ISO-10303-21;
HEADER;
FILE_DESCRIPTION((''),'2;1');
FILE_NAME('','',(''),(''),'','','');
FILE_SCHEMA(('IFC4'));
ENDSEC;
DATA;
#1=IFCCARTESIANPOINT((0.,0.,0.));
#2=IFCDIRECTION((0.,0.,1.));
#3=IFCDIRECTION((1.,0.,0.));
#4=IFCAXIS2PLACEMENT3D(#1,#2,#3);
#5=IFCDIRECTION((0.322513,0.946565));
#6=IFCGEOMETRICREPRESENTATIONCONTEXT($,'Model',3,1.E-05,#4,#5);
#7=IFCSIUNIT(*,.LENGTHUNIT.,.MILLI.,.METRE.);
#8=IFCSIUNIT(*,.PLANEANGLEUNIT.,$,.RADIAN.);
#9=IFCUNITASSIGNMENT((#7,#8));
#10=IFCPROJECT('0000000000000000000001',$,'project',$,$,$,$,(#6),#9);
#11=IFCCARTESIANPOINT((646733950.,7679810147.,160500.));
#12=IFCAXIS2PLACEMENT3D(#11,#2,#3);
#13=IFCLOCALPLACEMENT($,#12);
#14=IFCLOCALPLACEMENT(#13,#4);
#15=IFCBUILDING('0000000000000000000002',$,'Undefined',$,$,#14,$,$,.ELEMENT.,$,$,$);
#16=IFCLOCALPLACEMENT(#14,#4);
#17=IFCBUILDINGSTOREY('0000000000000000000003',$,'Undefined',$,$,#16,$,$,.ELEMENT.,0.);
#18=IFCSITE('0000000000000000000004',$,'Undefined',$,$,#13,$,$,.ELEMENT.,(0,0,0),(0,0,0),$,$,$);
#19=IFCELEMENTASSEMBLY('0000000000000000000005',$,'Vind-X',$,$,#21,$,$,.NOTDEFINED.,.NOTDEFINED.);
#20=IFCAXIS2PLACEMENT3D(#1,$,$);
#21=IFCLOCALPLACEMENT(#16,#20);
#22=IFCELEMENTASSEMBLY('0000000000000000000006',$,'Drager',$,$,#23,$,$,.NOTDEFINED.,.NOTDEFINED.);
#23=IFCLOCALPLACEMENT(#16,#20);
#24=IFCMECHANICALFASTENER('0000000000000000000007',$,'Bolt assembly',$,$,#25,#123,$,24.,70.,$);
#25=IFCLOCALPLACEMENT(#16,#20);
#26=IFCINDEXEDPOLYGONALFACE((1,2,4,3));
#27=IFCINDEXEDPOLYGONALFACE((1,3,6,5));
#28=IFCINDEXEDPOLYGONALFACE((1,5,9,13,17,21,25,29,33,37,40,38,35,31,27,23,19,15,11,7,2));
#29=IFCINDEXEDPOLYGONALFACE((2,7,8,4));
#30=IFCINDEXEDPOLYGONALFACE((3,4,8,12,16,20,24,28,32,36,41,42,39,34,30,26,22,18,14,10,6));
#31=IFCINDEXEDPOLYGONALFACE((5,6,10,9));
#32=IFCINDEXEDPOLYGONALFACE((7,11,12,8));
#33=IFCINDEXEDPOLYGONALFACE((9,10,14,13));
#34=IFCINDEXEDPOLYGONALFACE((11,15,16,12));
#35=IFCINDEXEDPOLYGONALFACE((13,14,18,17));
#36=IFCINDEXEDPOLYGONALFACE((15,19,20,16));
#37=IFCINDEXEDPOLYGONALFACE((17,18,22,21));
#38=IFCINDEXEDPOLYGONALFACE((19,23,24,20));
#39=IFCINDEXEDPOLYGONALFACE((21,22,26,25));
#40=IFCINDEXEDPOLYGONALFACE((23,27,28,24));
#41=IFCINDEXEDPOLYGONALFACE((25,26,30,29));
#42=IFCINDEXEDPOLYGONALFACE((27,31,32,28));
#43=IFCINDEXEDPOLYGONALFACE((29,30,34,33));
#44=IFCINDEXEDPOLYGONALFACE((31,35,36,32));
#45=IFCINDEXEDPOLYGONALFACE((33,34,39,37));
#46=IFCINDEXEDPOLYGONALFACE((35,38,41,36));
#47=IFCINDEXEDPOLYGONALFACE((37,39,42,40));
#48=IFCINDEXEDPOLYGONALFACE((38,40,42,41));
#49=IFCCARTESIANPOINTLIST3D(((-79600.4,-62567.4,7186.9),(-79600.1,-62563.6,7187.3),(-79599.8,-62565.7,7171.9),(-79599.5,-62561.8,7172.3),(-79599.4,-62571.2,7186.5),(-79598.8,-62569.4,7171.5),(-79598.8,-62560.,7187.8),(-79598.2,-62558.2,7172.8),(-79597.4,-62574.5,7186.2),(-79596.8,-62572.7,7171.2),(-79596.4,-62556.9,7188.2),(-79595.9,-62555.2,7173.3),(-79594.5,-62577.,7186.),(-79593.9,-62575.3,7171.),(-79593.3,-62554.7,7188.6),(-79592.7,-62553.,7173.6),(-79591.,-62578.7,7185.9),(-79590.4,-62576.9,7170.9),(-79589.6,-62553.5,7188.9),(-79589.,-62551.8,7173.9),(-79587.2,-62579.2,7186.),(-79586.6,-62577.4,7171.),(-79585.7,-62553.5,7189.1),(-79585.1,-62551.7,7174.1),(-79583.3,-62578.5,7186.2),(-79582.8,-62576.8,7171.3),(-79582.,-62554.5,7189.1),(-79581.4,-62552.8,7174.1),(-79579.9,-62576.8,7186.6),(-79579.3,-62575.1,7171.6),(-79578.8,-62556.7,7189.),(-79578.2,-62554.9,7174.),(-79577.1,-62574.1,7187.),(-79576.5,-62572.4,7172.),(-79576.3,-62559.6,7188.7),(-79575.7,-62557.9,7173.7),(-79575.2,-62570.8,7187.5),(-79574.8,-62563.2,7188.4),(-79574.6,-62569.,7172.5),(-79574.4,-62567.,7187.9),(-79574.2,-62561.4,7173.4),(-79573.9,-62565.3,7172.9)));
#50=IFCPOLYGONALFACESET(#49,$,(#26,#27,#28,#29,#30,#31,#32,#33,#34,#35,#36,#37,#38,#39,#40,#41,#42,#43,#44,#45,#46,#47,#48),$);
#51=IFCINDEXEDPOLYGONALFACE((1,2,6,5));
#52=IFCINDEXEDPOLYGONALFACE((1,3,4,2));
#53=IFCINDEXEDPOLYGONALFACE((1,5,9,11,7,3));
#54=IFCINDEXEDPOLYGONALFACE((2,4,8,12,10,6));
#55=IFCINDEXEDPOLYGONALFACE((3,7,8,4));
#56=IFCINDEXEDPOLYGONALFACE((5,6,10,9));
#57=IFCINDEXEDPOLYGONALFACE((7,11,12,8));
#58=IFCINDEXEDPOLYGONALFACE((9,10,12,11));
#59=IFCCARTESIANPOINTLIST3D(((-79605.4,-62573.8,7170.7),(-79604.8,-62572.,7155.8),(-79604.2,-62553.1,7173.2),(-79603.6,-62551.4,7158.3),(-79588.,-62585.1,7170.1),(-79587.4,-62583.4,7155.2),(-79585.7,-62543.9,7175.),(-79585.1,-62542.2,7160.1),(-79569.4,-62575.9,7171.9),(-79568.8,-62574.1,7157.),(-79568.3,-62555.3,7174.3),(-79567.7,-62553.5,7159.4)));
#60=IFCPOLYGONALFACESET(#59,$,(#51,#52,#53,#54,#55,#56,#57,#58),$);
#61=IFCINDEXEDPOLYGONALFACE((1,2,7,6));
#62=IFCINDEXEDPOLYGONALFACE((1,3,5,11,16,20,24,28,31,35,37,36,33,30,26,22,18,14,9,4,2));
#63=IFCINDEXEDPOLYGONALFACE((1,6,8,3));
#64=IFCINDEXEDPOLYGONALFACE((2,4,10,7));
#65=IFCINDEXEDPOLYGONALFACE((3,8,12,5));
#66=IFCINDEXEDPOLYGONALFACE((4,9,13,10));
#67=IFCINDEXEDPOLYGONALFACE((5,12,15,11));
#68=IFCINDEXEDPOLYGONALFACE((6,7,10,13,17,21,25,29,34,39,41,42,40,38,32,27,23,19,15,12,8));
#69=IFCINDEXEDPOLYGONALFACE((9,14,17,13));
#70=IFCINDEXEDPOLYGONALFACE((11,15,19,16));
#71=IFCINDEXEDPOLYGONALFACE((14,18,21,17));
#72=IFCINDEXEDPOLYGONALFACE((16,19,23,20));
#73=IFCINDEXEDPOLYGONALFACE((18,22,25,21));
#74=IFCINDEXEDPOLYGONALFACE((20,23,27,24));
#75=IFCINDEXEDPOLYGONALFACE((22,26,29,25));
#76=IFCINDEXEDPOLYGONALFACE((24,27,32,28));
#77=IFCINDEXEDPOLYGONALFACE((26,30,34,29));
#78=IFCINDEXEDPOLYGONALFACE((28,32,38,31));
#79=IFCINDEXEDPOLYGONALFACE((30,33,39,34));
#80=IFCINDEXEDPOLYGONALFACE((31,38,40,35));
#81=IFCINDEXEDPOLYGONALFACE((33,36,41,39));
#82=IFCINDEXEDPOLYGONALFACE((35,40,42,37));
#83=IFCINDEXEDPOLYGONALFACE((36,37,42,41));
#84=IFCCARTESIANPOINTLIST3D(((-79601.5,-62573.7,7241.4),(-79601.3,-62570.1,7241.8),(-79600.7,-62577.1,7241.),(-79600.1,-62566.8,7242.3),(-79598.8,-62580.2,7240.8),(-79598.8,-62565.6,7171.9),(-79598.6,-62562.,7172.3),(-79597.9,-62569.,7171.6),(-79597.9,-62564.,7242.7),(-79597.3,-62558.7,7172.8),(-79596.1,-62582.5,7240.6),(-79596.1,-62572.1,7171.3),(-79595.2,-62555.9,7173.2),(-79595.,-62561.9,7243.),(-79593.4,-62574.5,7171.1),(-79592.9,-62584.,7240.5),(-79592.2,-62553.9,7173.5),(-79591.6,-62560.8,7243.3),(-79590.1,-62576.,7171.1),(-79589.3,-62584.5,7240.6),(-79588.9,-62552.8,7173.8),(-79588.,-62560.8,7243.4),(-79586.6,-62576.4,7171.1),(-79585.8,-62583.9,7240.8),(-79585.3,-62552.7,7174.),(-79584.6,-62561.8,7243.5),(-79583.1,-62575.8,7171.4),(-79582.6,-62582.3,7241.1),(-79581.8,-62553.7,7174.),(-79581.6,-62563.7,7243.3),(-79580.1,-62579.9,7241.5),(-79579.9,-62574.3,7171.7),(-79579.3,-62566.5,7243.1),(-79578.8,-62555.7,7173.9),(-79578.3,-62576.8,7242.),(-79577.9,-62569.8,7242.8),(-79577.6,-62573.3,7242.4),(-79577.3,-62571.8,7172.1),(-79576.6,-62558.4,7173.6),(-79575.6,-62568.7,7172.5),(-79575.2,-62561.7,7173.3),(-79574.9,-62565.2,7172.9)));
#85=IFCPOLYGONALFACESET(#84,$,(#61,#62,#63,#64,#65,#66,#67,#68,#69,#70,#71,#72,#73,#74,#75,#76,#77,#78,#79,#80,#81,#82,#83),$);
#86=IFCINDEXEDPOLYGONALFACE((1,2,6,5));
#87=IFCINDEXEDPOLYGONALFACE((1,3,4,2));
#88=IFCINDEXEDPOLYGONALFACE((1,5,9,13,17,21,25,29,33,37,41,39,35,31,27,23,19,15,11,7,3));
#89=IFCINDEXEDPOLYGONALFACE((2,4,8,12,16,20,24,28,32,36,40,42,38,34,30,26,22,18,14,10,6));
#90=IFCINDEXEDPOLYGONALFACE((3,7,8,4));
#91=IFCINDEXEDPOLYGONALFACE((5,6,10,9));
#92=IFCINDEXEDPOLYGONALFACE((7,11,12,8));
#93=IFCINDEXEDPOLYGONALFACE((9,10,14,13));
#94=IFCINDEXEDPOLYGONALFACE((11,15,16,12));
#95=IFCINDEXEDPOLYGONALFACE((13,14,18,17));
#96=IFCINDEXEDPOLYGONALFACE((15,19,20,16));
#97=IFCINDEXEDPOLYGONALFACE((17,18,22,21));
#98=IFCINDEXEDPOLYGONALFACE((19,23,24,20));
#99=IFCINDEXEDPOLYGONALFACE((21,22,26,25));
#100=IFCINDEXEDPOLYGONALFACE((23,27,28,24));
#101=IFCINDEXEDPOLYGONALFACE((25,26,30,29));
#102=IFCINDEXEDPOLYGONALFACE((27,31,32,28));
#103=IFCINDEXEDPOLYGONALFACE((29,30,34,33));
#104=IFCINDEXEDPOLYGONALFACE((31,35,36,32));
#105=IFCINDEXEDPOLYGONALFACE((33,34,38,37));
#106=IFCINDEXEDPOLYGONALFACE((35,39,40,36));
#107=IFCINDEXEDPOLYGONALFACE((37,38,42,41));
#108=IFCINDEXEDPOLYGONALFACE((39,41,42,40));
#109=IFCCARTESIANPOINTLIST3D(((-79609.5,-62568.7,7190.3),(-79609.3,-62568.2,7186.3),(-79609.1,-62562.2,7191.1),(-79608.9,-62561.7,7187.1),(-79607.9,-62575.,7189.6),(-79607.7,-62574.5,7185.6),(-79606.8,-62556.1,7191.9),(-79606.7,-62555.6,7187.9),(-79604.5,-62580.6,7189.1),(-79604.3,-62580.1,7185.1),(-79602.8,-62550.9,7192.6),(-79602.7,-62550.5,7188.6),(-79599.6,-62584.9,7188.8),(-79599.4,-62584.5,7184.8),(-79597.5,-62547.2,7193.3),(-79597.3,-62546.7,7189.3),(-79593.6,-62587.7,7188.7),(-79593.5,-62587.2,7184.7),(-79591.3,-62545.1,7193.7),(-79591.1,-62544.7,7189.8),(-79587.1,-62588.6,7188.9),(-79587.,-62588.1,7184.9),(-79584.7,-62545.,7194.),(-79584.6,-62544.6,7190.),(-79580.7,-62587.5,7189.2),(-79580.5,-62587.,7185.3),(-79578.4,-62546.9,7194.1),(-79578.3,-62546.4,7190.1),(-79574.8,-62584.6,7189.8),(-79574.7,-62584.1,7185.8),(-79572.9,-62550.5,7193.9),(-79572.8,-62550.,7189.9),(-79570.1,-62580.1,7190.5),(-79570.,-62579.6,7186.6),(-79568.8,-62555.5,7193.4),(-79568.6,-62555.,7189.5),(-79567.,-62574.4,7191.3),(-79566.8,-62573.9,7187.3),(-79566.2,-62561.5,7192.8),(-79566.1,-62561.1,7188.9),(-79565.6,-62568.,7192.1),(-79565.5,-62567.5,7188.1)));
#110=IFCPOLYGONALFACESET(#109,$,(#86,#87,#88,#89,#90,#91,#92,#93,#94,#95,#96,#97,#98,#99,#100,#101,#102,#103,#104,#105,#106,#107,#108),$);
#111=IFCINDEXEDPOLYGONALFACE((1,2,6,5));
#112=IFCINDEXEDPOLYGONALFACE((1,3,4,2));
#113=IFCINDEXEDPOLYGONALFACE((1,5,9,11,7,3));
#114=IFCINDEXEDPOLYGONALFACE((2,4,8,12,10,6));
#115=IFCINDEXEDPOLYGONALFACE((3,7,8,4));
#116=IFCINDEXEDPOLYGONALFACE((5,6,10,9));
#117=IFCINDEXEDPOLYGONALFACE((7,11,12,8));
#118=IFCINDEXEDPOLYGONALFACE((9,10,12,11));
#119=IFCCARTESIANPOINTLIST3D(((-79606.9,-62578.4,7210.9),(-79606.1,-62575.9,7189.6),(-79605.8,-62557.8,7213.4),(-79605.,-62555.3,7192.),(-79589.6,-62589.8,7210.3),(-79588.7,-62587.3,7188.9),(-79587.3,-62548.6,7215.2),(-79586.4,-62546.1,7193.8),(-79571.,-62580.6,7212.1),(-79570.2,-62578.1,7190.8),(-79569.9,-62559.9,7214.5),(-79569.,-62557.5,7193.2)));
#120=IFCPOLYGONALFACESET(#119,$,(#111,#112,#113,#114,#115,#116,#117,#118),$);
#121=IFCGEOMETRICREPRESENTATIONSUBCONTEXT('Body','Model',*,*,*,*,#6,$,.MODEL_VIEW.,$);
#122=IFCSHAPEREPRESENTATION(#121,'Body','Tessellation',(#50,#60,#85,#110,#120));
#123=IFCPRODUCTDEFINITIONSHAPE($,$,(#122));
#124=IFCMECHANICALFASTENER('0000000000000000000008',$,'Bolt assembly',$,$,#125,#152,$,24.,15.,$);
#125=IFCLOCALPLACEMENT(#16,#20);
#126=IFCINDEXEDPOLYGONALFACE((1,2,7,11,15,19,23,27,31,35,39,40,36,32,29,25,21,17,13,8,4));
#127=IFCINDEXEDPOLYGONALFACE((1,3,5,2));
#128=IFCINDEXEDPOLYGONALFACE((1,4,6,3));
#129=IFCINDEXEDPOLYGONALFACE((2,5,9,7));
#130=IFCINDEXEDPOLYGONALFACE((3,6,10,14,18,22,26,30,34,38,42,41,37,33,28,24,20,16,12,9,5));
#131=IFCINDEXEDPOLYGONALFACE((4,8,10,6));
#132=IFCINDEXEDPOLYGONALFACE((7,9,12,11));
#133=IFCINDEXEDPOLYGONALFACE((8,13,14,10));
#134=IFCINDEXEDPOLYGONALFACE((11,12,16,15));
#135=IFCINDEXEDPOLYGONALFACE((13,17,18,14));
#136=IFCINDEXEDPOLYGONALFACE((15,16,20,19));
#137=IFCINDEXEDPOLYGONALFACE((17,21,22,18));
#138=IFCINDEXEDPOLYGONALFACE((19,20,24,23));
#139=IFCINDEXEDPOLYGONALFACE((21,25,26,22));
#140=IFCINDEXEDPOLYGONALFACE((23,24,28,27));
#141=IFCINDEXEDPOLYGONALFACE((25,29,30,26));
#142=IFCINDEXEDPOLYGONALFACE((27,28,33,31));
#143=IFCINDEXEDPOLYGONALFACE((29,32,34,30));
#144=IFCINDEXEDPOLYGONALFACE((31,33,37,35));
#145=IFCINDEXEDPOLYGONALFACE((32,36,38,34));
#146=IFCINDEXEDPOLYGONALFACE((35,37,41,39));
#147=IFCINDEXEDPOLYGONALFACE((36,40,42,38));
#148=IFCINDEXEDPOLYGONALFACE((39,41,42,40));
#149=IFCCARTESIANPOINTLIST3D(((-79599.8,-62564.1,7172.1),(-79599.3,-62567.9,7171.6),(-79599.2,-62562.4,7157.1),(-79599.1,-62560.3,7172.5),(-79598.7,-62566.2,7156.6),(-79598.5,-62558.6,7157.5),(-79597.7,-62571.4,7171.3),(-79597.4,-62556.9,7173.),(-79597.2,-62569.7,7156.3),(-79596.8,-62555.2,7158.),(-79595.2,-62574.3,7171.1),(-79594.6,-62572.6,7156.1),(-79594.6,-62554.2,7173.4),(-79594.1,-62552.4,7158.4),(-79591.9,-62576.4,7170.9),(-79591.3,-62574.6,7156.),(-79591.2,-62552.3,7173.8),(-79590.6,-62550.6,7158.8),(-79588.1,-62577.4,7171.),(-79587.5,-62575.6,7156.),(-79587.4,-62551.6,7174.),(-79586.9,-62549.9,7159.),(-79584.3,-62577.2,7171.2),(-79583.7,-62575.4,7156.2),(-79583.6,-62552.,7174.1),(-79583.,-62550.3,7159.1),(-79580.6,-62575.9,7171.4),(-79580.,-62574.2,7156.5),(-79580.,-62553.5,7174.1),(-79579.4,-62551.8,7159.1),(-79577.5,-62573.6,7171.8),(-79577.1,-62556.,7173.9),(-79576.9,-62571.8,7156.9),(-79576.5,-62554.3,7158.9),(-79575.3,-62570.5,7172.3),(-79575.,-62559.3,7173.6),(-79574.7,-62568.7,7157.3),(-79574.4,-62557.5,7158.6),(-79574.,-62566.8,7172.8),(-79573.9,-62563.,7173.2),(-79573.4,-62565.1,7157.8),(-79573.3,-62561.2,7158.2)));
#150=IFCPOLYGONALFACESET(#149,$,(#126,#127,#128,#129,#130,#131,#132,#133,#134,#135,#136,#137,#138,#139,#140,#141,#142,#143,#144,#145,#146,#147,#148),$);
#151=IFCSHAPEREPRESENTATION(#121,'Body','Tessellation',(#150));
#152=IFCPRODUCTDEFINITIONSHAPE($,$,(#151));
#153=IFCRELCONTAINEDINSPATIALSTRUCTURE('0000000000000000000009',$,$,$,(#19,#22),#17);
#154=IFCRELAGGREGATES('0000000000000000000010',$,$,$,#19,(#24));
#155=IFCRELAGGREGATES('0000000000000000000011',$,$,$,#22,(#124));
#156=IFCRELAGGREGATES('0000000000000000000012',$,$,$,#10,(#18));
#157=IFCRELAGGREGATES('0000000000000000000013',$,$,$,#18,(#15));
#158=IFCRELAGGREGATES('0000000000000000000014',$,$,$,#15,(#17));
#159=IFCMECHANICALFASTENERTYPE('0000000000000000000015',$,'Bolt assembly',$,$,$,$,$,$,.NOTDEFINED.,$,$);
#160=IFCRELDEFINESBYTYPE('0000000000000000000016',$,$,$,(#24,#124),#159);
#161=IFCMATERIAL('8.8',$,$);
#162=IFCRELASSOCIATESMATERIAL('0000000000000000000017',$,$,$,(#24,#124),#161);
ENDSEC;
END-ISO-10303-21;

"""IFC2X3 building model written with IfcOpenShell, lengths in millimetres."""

from ifc_helpers import new_model, si_unit, direction, frame, origin_with_axes, origin_2d_with_axis, place, context, subcontext, project, spatial, polyline, circle, outline, extrude, source, transform, mapped, material, type_object, element, aggregate, save


model = new_model("IFC2X3")

# Units and contexts
model_context = context("Model", 3, precision=1e-05, world=origin_with_axes(), true_north=direction((0.322513, 0.946565)))
body_context = subcontext(model_context, "Body", "Model", "MODEL_VIEW")
ifc_project = project(units=[si_unit("LENGTHUNIT", "METRE", prefix="MILLI"), si_unit("PLANEANGLEUNIT", "RADIAN")], contexts=[model_context])

# Site, building, storey
site_placement = place(None, frame((646733950.0, 7679810147.0, 160500.0), z_axis=(0.0, 0.0, 1.0), x_axis=(1.0, 0.0, 0.0)))
site = spatial("IfcSite", under=ifc_project, at=site_placement, Name="Undefined", CompositionType="ELEMENT", RefLatitude=(0, 0, 0), RefLongitude=(0, 0, 0))
building_placement = place(site_placement, origin_with_axes())
building = spatial("IfcBuilding", under=site, at=building_placement, Name="Undefined", CompositionType="ELEMENT")
storey_placement = place(building_placement, origin_with_axes())
storey = spatial("IfcBuildingStorey", under=building, at=storey_placement, Name="Undefined", CompositionType="ELEMENT", Elevation=0.0)

# Element assembly
assembly_1_placement = place(storey_placement, origin_with_axes())
assembly_1 = element("IfcElementAssembly", 1, at=assembly_1_placement, inside=storey, Name="Vind-X", AssemblyPlace="NOTDEFINED", PredefinedType="NOTDEFINED")

# Element assembly
assembly_2_placement = place(storey_placement, origin_with_axes())
assembly_2 = element("IfcElementAssembly", 2, at=assembly_2_placement, inside=storey, Name="Drager", AssemblyPlace="NOTDEFINED", PredefinedType="NOTDEFINED")

# Mechanical fasteners
ifc_material_1 = material(Name="8.8")
mechanical_fastener_type = type_object("IfcMechanicalFastenerType", Name="Bolt assembly")
shared_shape_1 = source(origin_with_axes(), body_context, "Body", "SweptSolid", [
    extrude(circle(Radius=13.0, at=origin_2d_with_axis()), frame((0.0, 0.0, 0.0), z_axis=(0.0, 1.0, 0.0), x_axis=(1.0, 0.0, 0.0)), (0.0, 0.0, 1.0), 15.1),
    extrude(outline(polyline([(18.0, -10.4), (18.0, 10.4), (0.0, 20.8), (-18.0, 10.4), (-18.0, -10.4), (0.0, -20.8), (18.0, -10.4)])), frame((0.0, -15.0, 0.0), z_axis=(0.0, 1.0, 0.0), x_axis=(1.0, 0.0, 0.0)), (0.0, 0.0, 1.0), 15.0),
    extrude(circle(Radius=12.0, at=origin_2d_with_axis()), frame((0.0, 0.0, 0.0), z_axis=(0.0, 1.0, 0.0), x_axis=(1.0, 0.0, 0.0)), (0.0, 0.0, 1.0), 70.0),
    extrude(circle(Radius=22.0, at=origin_2d_with_axis()), frame((0.0, 15.0, 0.0), z_axis=(0.0, 1.0, 0.0), x_axis=(1.0, 0.0, 0.0)), (0.0, 0.0, 1.0), 4.0),
    extrude(outline(polyline([(18.0, -10.4), (18.0, 10.4), (0.0, 20.8), (-18.0, 10.4), (-18.0, -10.4), (0.0, -20.8), (18.0, -10.4)])), frame((0.0, 19.0, 0.0), z_axis=(0.0, 1.0, 0.0), x_axis=(1.0, 0.0, 0.0)), (0.0, 0.0, 1.0), 21.5),
])
mechanical_fastener_1_placement = place(assembly_1_placement, frame((-79586.8, -62564.5, 7172.5), z_axis=(0.891424, 0.444742, 0.08699), x_axis=(-0.451462, 0.888199, 0.085352)))
mechanical_fastener_1 = element("IfcMechanicalFastener", 3, at=mechanical_fastener_1_placement, type_object=mechanical_fastener_type, material=ifc_material_1, Name="Bolt assembly", NominalDiameter=24.0, NominalLength=70.0, context=body_context, shape_type="MappedRepresentation", body=[
    mapped(shared_shape_1, transform((0.0, 0.0, 0.0))),
])
aggregate(assembly_1, [mechanical_fastener_1])
shared_shape_2 = source(origin_with_axes(), body_context, "Body", "SweptSolid", [
    extrude(circle(Radius=13.0, at=origin_2d_with_axis()), frame((0.0, -7.5, 0.0), z_axis=(0.0, 1.0, 0.0), x_axis=(1.0, 0.0, 0.0)), (0.0, 0.0, 1.0), 15.1),
])
mechanical_fastener_2_placement = place(assembly_2_placement, frame((-79586.5, -62563.6, 7165.1), z_axis=(-0.320109, -0.93951, -0.121869), x_axis=(-0.946565, 0.322513, 0.0)))
mechanical_fastener_2 = element("IfcMechanicalFastener", 4, at=mechanical_fastener_2_placement, type_object=mechanical_fastener_type, material=ifc_material_1, Name="Bolt assembly", NominalDiameter=24.0, NominalLength=15.0, context=body_context, shape_type="MappedRepresentation", body=[
    mapped(shared_shape_2, transform((0.0, 0.0, 0.0))),
])

aggregate(assembly_2, [mechanical_fastener_2])

save(model, "model.ifc")
